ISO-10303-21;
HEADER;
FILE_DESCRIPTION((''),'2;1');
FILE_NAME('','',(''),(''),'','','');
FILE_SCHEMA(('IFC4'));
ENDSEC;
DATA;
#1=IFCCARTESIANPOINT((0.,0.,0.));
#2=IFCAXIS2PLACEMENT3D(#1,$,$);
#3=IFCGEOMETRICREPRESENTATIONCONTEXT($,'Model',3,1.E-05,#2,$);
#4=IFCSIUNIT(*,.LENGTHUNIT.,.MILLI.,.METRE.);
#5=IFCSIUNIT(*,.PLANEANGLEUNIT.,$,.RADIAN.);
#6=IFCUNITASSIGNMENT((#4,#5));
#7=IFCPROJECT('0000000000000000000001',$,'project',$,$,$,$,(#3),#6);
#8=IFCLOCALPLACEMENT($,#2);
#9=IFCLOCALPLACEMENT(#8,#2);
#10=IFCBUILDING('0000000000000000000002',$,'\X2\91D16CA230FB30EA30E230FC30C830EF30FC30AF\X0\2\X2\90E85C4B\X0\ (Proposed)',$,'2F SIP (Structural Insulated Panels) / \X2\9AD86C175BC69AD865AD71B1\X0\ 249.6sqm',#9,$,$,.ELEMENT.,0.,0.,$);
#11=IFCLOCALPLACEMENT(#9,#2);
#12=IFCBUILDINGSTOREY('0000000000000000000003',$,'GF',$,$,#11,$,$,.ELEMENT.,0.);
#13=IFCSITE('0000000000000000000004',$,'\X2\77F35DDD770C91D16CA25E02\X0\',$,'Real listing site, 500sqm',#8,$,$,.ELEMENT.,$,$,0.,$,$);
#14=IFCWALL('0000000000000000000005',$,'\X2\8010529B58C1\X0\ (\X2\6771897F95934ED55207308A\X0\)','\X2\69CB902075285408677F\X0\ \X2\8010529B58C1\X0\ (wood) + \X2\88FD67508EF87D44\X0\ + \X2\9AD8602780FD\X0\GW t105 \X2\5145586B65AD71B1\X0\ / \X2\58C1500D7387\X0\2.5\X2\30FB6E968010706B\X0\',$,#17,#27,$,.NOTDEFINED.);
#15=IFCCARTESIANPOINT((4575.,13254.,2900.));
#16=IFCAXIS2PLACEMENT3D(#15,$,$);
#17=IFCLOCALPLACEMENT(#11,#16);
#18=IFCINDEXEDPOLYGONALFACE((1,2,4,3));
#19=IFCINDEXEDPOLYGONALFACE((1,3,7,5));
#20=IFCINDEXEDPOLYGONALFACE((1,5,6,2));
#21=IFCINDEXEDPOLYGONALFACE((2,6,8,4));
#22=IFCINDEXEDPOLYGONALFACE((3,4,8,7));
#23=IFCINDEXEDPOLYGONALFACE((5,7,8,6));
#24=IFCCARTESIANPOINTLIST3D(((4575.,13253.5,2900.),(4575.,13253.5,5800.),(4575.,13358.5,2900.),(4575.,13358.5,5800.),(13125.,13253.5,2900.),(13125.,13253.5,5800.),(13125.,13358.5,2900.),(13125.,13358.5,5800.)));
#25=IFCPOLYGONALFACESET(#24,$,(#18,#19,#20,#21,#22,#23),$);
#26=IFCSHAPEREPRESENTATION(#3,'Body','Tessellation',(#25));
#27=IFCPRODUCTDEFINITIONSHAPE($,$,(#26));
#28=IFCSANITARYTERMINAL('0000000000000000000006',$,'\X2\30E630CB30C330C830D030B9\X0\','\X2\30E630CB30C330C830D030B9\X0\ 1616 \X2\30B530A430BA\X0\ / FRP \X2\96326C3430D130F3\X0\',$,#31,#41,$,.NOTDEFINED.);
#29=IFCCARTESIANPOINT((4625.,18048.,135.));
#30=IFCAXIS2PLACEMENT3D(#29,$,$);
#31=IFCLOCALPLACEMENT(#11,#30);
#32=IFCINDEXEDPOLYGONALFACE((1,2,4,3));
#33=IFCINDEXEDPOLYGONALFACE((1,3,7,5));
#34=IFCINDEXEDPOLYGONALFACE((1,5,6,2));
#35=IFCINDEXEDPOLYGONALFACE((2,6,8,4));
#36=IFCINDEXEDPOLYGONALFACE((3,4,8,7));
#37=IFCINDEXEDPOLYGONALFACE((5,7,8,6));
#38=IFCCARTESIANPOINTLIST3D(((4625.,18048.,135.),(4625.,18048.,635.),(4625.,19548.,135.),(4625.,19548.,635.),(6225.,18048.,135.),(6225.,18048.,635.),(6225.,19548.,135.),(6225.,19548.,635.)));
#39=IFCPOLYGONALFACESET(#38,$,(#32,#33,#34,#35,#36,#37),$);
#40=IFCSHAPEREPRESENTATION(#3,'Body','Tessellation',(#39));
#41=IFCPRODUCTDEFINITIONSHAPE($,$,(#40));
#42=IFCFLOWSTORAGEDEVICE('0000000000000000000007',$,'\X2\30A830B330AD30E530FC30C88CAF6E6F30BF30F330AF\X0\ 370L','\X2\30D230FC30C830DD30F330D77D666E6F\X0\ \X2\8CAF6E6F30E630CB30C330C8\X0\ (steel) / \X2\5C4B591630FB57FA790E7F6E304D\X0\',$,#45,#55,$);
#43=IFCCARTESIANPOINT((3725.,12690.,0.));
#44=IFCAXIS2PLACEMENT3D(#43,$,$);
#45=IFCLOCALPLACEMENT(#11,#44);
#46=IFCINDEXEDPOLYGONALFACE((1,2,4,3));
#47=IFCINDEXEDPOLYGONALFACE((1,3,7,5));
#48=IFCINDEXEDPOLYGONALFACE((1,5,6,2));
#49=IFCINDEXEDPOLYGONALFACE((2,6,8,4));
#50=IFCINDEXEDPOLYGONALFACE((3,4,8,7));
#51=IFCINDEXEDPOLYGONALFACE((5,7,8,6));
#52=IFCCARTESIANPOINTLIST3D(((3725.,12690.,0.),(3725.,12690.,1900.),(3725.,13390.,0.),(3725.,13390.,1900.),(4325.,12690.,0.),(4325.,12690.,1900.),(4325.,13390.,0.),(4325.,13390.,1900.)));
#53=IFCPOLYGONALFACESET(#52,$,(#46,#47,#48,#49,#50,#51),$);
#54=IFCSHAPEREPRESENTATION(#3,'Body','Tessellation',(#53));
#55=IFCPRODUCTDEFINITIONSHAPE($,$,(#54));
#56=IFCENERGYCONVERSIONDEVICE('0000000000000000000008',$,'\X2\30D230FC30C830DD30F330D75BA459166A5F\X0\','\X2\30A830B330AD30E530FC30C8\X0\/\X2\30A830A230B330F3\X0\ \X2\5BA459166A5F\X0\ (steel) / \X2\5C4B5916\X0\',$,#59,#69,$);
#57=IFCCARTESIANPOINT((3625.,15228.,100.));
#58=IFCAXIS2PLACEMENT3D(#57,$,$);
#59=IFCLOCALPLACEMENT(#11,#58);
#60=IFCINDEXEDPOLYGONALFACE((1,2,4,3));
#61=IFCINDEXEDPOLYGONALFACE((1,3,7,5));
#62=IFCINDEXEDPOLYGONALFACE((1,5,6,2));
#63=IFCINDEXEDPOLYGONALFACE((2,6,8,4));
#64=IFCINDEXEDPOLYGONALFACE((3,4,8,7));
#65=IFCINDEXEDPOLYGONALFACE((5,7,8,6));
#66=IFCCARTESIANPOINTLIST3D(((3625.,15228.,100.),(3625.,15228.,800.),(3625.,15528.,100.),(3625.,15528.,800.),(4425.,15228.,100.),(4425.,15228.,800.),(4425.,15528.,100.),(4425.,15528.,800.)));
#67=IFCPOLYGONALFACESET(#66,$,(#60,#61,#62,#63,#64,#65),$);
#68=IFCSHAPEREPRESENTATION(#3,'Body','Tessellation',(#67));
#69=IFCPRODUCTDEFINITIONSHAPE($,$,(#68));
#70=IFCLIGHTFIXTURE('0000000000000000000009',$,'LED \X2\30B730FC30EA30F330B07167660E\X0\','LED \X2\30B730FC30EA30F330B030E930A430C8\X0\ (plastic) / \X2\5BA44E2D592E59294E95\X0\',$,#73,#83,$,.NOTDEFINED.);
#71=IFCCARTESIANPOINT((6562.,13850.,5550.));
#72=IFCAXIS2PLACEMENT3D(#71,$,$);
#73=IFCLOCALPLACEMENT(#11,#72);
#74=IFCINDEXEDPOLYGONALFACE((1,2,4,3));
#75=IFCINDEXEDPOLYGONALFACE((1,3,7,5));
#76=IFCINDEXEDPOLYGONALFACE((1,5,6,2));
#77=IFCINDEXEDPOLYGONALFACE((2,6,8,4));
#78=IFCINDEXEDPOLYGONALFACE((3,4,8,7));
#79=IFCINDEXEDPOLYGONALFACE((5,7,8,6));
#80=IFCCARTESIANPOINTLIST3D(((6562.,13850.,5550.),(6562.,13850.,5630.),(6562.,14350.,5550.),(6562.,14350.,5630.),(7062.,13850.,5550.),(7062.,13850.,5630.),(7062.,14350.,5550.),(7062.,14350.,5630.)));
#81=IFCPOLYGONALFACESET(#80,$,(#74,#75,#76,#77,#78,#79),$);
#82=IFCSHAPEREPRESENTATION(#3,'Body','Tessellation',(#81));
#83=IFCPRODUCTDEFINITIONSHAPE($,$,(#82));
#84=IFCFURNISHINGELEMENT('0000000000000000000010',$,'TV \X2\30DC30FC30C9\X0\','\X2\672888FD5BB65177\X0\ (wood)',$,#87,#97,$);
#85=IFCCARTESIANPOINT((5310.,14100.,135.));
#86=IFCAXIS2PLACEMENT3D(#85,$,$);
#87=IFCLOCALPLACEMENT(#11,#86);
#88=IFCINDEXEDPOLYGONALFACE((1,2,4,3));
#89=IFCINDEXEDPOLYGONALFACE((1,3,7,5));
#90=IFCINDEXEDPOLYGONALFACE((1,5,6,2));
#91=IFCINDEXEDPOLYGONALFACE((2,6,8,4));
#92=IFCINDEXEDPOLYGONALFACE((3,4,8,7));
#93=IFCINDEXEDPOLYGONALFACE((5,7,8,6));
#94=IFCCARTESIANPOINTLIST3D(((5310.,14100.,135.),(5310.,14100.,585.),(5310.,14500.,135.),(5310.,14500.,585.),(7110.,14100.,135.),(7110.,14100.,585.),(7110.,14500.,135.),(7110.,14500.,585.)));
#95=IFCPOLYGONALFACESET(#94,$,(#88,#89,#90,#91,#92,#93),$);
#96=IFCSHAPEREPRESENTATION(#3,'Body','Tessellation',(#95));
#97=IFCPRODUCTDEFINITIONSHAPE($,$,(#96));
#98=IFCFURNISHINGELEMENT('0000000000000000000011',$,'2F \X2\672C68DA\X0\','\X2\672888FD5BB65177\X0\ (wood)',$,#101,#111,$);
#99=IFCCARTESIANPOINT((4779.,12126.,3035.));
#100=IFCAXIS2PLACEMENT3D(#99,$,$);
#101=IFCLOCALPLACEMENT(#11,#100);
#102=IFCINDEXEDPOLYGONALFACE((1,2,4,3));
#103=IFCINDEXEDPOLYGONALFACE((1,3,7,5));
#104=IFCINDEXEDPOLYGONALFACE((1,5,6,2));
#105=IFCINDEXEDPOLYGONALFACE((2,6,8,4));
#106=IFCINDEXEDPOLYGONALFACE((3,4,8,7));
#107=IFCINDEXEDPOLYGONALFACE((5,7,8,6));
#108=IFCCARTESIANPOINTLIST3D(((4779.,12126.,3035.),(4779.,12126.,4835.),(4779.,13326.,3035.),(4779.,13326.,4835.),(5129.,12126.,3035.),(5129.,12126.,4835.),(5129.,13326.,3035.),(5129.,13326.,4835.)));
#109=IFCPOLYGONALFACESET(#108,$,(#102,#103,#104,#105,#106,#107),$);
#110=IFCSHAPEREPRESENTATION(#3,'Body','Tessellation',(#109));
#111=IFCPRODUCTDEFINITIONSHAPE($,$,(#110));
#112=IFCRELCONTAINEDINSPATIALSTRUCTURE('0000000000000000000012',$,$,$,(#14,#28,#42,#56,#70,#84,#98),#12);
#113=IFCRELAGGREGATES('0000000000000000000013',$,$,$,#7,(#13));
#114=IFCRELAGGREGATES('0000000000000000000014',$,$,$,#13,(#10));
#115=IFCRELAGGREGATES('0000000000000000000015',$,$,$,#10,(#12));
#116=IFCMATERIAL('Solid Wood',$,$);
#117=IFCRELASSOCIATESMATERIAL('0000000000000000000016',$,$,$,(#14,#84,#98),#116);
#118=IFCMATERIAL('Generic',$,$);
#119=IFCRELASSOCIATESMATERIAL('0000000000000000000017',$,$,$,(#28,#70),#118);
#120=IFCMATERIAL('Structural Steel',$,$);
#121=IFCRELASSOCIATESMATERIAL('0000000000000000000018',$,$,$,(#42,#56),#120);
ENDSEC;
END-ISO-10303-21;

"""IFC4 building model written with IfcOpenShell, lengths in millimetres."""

from ifc_helpers import new_model, si_unit, frame, frame_2d, origin, place, context, project, spatial, rectangle, extrude, material, element, save


model = new_model("IFC4")

# Units and contexts
model_context = context("Model", 3, precision=1e-05, world=origin())
ifc_project = project(units=[si_unit("LENGTHUNIT", "METRE", prefix="MILLI"), si_unit("PLANEANGLEUNIT", "RADIAN")], contexts=[model_context])

# Site, building, storey
site_placement = place(None, origin())
site = spatial("IfcSite", under=ifc_project, at=site_placement, Name="石川県金沢市", ObjectType="Real listing site, 500sqm", CompositionType="ELEMENT", RefElevation=0.0)
building_placement = place(site_placement, origin())
building = spatial("IfcBuilding", under=site, at=building_placement, Name="金沢・リモートワーク2部屋 (Proposed)", ObjectType="2F SIP (Structural Insulated Panels) / 高気密高断熱 249.6sqm", CompositionType="ELEMENT", ElevationOfRefHeight=0.0, ElevationOfTerrain=0.0)
storey_placement = place(building_placement, origin())
storey = spatial("IfcBuildingStorey", under=building, at=storey_placement, Name="GF", CompositionType="ELEMENT", Elevation=0.0)

# Shared definitions
ifc_material_1 = material(Name="Solid Wood")

# Wall
wall_1_placement = place(storey_placement, frame((4575.0, 13254.0, 2900.0)))
element("IfcWall", 1, at=wall_1_placement, inside=storey, material=ifc_material_1, Name="耐力壁 (東西間仕切り)", Description="構造用合板 耐力壁 (wood) + 製材軸組 + 高性能GW t105 充填断熱 / 壁倍率2.5・準耐火", PredefinedType="NOTDEFINED", context=model_context, shape_type="SweptSolid", body=[
    extrude(rectangle(XDim=8550.0, YDim=105.0, at=frame_2d((4275.0, 52.0))), frame((4575.0, 13254.0, 2900.0)), (0.0, 0.0, 1.0), 2900.0),
])

# Sanitary terminal
ifc_material_2 = material(Name="Generic")
sanitary_terminal_placement = place(storey_placement, frame((4625.0, 18048.0, 135.0)))
element("IfcSanitaryTerminal", 2, at=sanitary_terminal_placement, inside=storey, material=ifc_material_2, Name="ユニットバス", Description="ユニットバス 1616 サイズ / FRP 防水パン", PredefinedType="NOTDEFINED", context=model_context, shape_type="SweptSolid", body=[
    extrude(rectangle(XDim=1600.0, YDim=1500.0, at=frame_2d((800.0, 750.0))), frame((4625.0, 18048.0, 135.0)), (0.0, 0.0, 1.0), 500.0),
])

# Flow storage device
ifc_material_3 = material(Name="Structural Steel")
flow_storage_device_placement = place(storey_placement, frame((3725.0, 12690.0, 0.0)))
element("IfcFlowStorageDevice", 3, at=flow_storage_device_placement, inside=storey, material=ifc_material_3, Name="エコキュート貯湯タンク 370L", Description="ヒートポンプ給湯 貯湯ユニット (steel) / 屋外・基礎置き", context=model_context, shape_type="SweptSolid", body=[
    extrude(rectangle(XDim=600.0, YDim=700.0, at=frame_2d((300.0, 350.0))), frame((3725.0, 12690.0, 0.0)), (0.0, 0.0, 1.0), 1900.0),
])

# Energy conversion device
energy_conversion_device_placement = place(storey_placement, frame((3625.0, 15228.0, 100.0)))
element("IfcEnergyConversionDevice", 4, at=energy_conversion_device_placement, inside=storey, material=ifc_material_3, Name="ヒートポンプ室外機", Description="エコキュート/エアコン 室外機 (steel) / 屋外", context=model_context, shape_type="SweptSolid", body=[
    extrude(rectangle(XDim=800.0, YDim=300.0, at=frame_2d((400.0, 150.0))), frame((3625.0, 15228.0, 100.0)), (0.0, 0.0, 1.0), 700.0),
])

# Light fixture
light_fixture_placement = place(storey_placement, frame((6562.0, 13850.0, 5550.0)))
element("IfcLightFixture", 5, at=light_fixture_placement, inside=storey, material=ifc_material_2, Name="LED シーリング照明", Description="LED シーリングライト (plastic) / 室中央天井", PredefinedType="NOTDEFINED", context=model_context, shape_type="SweptSolid", body=[
    extrude(rectangle(XDim=500.0, YDim=500.0, at=frame_2d((250.0, 250.0))), frame((6562.0, 13850.0, 5550.0)), (0.0, 0.0, 1.0), 80.0),
])

# Furnishing elements
furnishing_1_placement = place(storey_placement, frame((5310.0, 14100.0, 135.0)))
element("IfcFurnishingElement", 6, at=furnishing_1_placement, inside=storey, material=ifc_material_1, Name="TV ボード", Description="木製家具 (wood)", context=model_context, shape_type="SweptSolid", body=[
    extrude(rectangle(XDim=1800.0, YDim=400.0, at=frame_2d((900.0, 200.0))), frame((5310.0, 14100.0, 135.0)), (0.0, 0.0, 1.0), 450.0),
])
furnishing_2_placement = place(storey_placement, frame((4779.0, 12126.0, 3035.0)))
element("IfcFurnishingElement", 7, at=furnishing_2_placement, inside=storey, material=ifc_material_1, Name="2F 本棚", Description="木製家具 (wood)", context=model_context, shape_type="SweptSolid", body=[
    extrude(rectangle(XDim=350.0, YDim=1200.0, at=frame_2d((175.0, 600.0))), frame((4779.0, 12126.0, 3035.0)), (0.0, 0.0, 1.0), 1800.0),
])

save(model, "model.ifc")
